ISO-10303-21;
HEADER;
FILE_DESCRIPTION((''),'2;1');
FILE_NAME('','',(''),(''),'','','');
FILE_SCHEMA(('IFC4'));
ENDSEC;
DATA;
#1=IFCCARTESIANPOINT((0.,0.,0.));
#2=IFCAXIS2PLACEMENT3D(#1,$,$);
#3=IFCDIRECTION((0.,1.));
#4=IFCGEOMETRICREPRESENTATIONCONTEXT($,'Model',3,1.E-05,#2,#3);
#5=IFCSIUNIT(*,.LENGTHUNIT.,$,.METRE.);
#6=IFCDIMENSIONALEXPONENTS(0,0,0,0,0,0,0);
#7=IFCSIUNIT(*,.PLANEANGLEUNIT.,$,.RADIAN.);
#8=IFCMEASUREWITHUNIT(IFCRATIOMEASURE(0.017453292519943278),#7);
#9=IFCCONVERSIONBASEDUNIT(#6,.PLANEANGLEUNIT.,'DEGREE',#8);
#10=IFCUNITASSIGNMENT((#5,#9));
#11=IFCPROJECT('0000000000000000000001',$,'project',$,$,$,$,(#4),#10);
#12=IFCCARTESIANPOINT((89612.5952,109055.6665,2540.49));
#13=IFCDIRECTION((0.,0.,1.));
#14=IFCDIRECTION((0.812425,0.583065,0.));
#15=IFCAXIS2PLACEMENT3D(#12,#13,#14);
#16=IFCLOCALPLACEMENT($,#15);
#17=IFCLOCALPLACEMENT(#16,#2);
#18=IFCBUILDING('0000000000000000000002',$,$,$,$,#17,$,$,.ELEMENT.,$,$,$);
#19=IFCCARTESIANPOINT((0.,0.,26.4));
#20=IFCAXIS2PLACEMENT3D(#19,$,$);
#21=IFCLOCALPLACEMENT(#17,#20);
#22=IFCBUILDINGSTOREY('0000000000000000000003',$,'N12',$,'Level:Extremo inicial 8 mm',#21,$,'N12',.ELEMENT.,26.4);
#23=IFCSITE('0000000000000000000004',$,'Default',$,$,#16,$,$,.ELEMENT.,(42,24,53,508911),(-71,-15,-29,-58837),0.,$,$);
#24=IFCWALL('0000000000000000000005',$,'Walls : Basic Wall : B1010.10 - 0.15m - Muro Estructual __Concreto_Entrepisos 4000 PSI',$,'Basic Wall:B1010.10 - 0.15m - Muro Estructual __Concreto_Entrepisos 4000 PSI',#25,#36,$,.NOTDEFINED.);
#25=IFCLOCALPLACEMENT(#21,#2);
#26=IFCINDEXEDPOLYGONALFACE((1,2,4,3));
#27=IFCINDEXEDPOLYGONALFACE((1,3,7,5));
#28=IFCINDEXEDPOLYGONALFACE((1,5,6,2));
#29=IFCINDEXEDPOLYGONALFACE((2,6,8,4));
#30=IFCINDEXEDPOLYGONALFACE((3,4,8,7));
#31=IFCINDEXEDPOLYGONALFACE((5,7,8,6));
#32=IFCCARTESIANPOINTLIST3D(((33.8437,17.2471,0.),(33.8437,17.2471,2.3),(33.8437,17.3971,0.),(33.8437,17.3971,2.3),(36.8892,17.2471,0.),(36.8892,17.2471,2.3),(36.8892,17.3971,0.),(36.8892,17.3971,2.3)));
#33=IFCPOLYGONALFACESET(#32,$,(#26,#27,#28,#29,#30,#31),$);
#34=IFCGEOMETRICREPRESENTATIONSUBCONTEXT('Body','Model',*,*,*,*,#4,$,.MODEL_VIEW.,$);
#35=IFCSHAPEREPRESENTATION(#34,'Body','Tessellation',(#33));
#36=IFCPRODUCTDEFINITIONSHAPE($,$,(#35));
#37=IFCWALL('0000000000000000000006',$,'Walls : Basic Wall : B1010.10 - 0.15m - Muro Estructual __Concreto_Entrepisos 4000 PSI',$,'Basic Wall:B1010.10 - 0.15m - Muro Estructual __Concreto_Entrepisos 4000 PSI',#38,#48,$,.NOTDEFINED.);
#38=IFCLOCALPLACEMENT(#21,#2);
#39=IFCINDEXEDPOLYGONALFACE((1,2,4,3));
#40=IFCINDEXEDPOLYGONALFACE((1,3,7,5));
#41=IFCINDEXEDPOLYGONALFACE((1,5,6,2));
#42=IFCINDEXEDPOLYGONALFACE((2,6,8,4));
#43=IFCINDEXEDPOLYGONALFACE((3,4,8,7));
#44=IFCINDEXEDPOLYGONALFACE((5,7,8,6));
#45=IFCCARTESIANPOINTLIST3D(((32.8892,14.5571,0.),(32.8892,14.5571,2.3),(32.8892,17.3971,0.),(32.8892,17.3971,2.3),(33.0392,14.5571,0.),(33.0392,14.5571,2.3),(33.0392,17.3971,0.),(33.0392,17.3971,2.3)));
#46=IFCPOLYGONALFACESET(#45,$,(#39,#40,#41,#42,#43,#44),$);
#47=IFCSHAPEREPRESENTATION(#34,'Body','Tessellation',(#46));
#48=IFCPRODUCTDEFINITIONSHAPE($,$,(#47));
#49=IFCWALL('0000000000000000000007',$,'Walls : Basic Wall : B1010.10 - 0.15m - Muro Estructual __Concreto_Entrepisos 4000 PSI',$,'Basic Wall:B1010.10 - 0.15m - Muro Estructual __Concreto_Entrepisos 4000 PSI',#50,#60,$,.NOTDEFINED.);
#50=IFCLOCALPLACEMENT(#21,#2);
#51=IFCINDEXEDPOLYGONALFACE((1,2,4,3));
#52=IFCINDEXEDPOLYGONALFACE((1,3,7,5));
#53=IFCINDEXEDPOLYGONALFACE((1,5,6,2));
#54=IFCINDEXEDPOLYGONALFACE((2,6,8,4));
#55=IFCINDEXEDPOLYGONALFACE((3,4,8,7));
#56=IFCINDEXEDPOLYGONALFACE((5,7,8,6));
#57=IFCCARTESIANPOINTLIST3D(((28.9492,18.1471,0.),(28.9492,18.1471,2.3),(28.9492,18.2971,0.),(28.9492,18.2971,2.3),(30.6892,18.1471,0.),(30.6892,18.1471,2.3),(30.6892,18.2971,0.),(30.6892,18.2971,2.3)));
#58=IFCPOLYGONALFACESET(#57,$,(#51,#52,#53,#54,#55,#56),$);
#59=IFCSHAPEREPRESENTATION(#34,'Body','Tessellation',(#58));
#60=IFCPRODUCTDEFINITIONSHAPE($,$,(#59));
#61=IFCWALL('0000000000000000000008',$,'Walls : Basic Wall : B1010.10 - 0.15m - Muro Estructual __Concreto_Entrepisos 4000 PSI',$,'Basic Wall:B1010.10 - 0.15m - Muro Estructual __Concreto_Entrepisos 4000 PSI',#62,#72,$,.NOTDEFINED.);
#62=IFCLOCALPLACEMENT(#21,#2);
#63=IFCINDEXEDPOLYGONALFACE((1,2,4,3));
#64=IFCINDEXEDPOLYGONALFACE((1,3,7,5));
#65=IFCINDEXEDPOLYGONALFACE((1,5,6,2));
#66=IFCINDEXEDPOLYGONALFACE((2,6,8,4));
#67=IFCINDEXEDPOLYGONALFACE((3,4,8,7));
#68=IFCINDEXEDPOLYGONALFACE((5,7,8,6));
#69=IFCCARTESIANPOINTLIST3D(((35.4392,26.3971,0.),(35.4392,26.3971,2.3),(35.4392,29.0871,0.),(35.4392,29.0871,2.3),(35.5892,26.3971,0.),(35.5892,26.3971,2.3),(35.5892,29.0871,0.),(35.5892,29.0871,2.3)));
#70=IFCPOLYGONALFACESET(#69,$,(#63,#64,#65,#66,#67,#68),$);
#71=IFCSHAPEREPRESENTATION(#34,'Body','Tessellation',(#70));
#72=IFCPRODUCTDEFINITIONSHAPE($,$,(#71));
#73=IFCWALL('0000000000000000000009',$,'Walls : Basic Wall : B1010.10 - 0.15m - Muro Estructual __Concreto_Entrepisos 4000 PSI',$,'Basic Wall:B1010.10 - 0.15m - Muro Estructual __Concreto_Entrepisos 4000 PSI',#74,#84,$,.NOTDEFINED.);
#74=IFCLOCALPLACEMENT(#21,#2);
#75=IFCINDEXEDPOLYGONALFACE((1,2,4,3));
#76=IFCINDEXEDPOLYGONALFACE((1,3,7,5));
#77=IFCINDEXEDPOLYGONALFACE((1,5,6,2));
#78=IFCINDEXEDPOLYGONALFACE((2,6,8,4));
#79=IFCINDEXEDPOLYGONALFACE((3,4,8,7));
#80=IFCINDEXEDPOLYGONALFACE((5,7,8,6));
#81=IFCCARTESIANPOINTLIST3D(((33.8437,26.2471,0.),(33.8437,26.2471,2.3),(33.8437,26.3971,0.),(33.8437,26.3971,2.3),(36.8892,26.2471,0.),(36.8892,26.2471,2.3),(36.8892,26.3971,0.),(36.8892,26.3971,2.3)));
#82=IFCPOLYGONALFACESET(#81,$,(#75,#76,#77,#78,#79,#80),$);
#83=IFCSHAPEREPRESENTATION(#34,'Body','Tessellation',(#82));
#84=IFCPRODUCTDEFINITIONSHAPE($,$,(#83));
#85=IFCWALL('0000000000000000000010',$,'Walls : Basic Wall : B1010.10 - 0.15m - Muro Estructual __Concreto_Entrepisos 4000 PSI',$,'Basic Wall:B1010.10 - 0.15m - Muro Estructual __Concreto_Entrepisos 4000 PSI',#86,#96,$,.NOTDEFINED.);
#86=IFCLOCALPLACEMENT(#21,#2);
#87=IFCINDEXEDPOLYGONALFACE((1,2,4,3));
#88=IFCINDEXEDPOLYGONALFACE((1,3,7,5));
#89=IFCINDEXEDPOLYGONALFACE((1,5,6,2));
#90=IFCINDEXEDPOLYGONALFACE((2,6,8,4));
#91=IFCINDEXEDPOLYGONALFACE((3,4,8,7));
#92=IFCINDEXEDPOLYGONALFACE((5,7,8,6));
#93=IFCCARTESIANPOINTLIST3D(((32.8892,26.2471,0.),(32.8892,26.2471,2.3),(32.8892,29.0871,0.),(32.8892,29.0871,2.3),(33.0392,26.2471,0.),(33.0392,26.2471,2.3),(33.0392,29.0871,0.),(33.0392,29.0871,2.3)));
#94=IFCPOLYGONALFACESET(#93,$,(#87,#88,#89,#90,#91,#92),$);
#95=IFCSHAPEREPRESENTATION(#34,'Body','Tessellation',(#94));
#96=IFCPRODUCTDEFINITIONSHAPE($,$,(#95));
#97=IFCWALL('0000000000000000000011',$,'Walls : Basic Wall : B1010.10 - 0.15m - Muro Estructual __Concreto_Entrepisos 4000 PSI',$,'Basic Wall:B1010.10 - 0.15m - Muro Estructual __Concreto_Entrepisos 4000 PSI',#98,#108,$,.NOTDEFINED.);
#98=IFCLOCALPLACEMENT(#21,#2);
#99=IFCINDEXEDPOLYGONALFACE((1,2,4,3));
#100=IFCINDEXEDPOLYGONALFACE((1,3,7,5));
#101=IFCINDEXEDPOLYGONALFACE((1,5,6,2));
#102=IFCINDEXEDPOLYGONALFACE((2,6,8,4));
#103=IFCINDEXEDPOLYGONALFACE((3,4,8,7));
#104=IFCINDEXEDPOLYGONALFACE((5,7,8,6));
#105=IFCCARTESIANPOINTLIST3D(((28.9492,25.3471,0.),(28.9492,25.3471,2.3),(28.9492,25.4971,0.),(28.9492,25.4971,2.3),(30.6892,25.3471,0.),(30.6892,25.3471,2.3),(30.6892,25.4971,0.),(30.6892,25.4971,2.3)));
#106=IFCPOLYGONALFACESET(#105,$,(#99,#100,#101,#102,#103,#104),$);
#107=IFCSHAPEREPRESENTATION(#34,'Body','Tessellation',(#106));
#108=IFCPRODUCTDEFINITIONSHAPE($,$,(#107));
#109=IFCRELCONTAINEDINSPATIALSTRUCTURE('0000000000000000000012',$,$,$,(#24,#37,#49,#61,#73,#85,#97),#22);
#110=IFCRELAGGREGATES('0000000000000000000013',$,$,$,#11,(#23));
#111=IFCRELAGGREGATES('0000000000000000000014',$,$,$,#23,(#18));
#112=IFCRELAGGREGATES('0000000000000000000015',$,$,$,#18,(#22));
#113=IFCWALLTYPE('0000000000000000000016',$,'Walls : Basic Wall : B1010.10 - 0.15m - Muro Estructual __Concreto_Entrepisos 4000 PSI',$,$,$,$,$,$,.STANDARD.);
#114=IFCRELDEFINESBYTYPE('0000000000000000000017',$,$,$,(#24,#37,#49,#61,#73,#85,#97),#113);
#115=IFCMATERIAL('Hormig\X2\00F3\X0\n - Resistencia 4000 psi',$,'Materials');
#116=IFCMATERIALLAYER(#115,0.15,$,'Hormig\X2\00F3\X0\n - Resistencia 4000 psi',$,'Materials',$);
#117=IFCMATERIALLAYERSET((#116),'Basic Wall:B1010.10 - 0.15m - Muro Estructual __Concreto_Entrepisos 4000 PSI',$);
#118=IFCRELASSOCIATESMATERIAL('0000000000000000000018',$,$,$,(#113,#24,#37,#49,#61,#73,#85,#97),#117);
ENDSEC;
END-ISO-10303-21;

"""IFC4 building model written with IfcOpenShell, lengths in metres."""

from ifc_helpers import new_model, entity, si_unit, converted_unit, direction, frame, frame_2d, origin, place, context, subcontext, project, spatial, rectangle, extrude, material, layer, layer_set, layer_usage, type_object, element, save


model = new_model("IFC4")

# Units and contexts
model_context = context("Model", 3, precision=1e-05, world=origin(), true_north=direction((0.0, 1.0)))
body_context = subcontext(model_context, "Body", "Model", "MODEL_VIEW")
ifc_project = project(units=[si_unit("LENGTHUNIT", "METRE"), converted_unit("PLANEANGLEUNIT", "DEGREE", entity("IfcRatioMeasure", 0.017453292519943278), si_unit("PLANEANGLEUNIT", "RADIAN"), dimensions=[0, 0, 0, 0, 0, 0, 0])], contexts=[model_context])

# Site, building, storey
site_placement = place(None, frame((89612.5952, 109055.6665, 2540.49), z_axis=(0.0, 0.0, 1.0), x_axis=(0.812425, 0.583065, 0.0)))
site = spatial("IfcSite", under=ifc_project, at=site_placement, Name="Default", CompositionType="ELEMENT", RefLatitude=(42, 24, 53, 508911), RefLongitude=(-71, -15, -29, -58837), RefElevation=0.0)
building_placement = place(site_placement, origin())
building = spatial("IfcBuilding", under=site, at=building_placement, CompositionType="ELEMENT")
storey_placement = place(building_placement, frame((0.0, 0.0, 26.4)))
storey = spatial("IfcBuildingStorey", under=building, at=storey_placement, Name="N12", ObjectType="Level:Extremo inicial 8 mm", LongName="N12", CompositionType="ELEMENT", Elevation=26.4)

# Walls
ifc_material = material(Name="Hormigón - Resistencia 4000 psi", Category="Materials")
ifc_layer_1 = layer(ifc_material, 0.15, Name="Hormigón - Resistencia 4000 psi", Category="Materials")
ifc_layer_set_1 = layer_set([ifc_layer_1], Name="Basic Wall:B1010.10 - 0.15m - Muro Estructual __Concreto_Entrepisos 4000 PSI")
wall_type_1 = type_object("IfcWallType", Name="Walls : Basic Wall : B1010.10 - 0.15m - Muro Estructual __Concreto_Entrepisos 4000 PSI", PredefinedType="STANDARD", material=ifc_layer_set_1)
ifc_layer_usage_1 = layer_usage(ifc_layer_set_1, "AXIS2", "NEGATIVE", 0.075)
wall_1_placement = place(storey_placement, frame((36.8892, 17.3221, 0.0), z_axis=(0.0, 0.0, 1.0), x_axis=(-1.0, 0.0, 0.0)))
element("IfcWall", 1, at=wall_1_placement, inside=storey, type_object=wall_type_1, material=ifc_layer_usage_1, Name="Walls : Basic Wall : B1010.10 - 0.15m - Muro Estructual __Concreto_Entrepisos 4000 PSI", ObjectType="Basic Wall:B1010.10 - 0.15m - Muro Estructual __Concreto_Entrepisos 4000 PSI", PredefinedType="NOTDEFINED", context=body_context, shape_type="SweptSolid", body=[
    extrude(rectangle(XDim=3.0455, YDim=0.15, at=frame_2d((1.5228, 0.0), x_axis=(-1.0, 0.0))), origin(), (0.0, 0.0, 1.0), 2.3),
])
ifc_layer_usage_2 = layer_usage(ifc_layer_set_1, "AXIS2", "NEGATIVE", 0.075)
wall_2_placement = place(storey_placement, frame((32.9642, 14.5571, 0.0), z_axis=(0.0, 0.0, 1.0), x_axis=(0.0, 1.0, 0.0)))
element("IfcWall", 2, at=wall_2_placement, inside=storey, type_object=wall_type_1, material=ifc_layer_usage_2, Name="Walls : Basic Wall : B1010.10 - 0.15m - Muro Estructual __Concreto_Entrepisos 4000 PSI", ObjectType="Basic Wall:B1010.10 - 0.15m - Muro Estructual __Concreto_Entrepisos 4000 PSI", PredefinedType="NOTDEFINED", context=body_context, shape_type="SweptSolid", body=[
    extrude(rectangle(XDim=2.84, YDim=0.15, at=frame_2d((1.42, 0.0), x_axis=(-1.0, 0.0))), origin(), (0.0, 0.0, 1.0), 2.3),
])
ifc_layer_usage_3 = layer_usage(ifc_layer_set_1, "AXIS2", "NEGATIVE", 0.075)
wall_3_placement = place(storey_placement, frame((30.6892, 18.2221, 0.0), z_axis=(0.0, 0.0, 1.0), x_axis=(-1.0, 0.0, 0.0)))
element("IfcWall", 3, at=wall_3_placement, inside=storey, type_object=wall_type_1, material=ifc_layer_usage_3, Name="Walls : Basic Wall : B1010.10 - 0.15m - Muro Estructual __Concreto_Entrepisos 4000 PSI", ObjectType="Basic Wall:B1010.10 - 0.15m - Muro Estructual __Concreto_Entrepisos 4000 PSI", PredefinedType="NOTDEFINED", context=body_context, shape_type="SweptSolid", body=[
    extrude(rectangle(XDim=1.74, YDim=0.15, at=frame_2d((0.87, 0.0), x_axis=(-1.0, 0.0))), origin(), (0.0, 0.0, 1.0), 2.3),
])
ifc_layer_usage_4 = layer_usage(ifc_layer_set_1, "AXIS2", "POSITIVE", -0.075)
wall_4_placement = place(storey_placement, frame((35.5142, 29.0871, 0.0), z_axis=(0.0, 0.0, 1.0), x_axis=(0.0, -1.0, 0.0)))
element("IfcWall", 4, at=wall_4_placement, inside=storey, type_object=wall_type_1, material=ifc_layer_usage_4, Name="Walls : Basic Wall : B1010.10 - 0.15m - Muro Estructual __Concreto_Entrepisos 4000 PSI", ObjectType="Basic Wall:B1010.10 - 0.15m - Muro Estructual __Concreto_Entrepisos 4000 PSI", PredefinedType="NOTDEFINED", context=body_context, shape_type="SweptSolid", body=[
    extrude(rectangle(XDim=2.69, YDim=0.15, at=frame_2d((1.345, 0.0), x_axis=(-1.0, 0.0))), origin(), (0.0, 0.0, 1.0), 2.3),
])
ifc_layer_usage_5 = layer_usage(ifc_layer_set_1, "AXIS2", "POSITIVE", -0.075)
wall_5_placement = place(storey_placement, frame((36.8892, 26.3221, 0.0), z_axis=(0.0, 0.0, 1.0), x_axis=(-1.0, 0.0, 0.0)))
element("IfcWall", 5, at=wall_5_placement, inside=storey, type_object=wall_type_1, material=ifc_layer_usage_5, Name="Walls : Basic Wall : B1010.10 - 0.15m - Muro Estructual __Concreto_Entrepisos 4000 PSI", ObjectType="Basic Wall:B1010.10 - 0.15m - Muro Estructual __Concreto_Entrepisos 4000 PSI", PredefinedType="NOTDEFINED", context=body_context, shape_type="SweptSolid", body=[
    extrude(rectangle(XDim=3.0455, YDim=0.15, at=frame_2d((1.5228, 0.0), x_axis=(-1.0, 0.0))), origin(), (0.0, 0.0, 1.0), 2.3),
])
ifc_layer_usage_6 = layer_usage(ifc_layer_set_1, "AXIS2", "POSITIVE", -0.075)
wall_6_placement = place(storey_placement, frame((32.9642, 29.0871, 0.0), z_axis=(0.0, 0.0, 1.0), x_axis=(0.0, -1.0, 0.0)))
element("IfcWall", 6, at=wall_6_placement, inside=storey, type_object=wall_type_1, material=ifc_layer_usage_6, Name="Walls : Basic Wall : B1010.10 - 0.15m - Muro Estructual __Concreto_Entrepisos 4000 PSI", ObjectType="Basic Wall:B1010.10 - 0.15m - Muro Estructual __Concreto_Entrepisos 4000 PSI", PredefinedType="NOTDEFINED", context=body_context, shape_type="SweptSolid", body=[
    extrude(rectangle(XDim=2.84, YDim=0.15, at=frame_2d((1.42, 0.0), x_axis=(-1.0, 0.0))), origin(), (0.0, 0.0, 1.0), 2.3),
])
ifc_layer_usage_7 = layer_usage(ifc_layer_set_1, "AXIS2", "POSITIVE", -0.075)
wall_7_placement = place(storey_placement, frame((30.6892, 25.4221, 0.0), z_axis=(0.0, 0.0, 1.0), x_axis=(-1.0, 0.0, 0.0)))
element("IfcWall", 7, at=wall_7_placement, inside=storey, type_object=wall_type_1, material=ifc_layer_usage_7, Name="Walls : Basic Wall : B1010.10 - 0.15m - Muro Estructual __Concreto_Entrepisos 4000 PSI", ObjectType="Basic Wall:B1010.10 - 0.15m - Muro Estructual __Concreto_Entrepisos 4000 PSI", PredefinedType="NOTDEFINED", context=body_context, shape_type="SweptSolid", body=[
    extrude(rectangle(XDim=1.74, YDim=0.15, at=frame_2d((0.87, 0.0), x_axis=(-1.0, 0.0))), origin(), (0.0, 0.0, 1.0), 2.3),
])

save(model, "model.ifc")
